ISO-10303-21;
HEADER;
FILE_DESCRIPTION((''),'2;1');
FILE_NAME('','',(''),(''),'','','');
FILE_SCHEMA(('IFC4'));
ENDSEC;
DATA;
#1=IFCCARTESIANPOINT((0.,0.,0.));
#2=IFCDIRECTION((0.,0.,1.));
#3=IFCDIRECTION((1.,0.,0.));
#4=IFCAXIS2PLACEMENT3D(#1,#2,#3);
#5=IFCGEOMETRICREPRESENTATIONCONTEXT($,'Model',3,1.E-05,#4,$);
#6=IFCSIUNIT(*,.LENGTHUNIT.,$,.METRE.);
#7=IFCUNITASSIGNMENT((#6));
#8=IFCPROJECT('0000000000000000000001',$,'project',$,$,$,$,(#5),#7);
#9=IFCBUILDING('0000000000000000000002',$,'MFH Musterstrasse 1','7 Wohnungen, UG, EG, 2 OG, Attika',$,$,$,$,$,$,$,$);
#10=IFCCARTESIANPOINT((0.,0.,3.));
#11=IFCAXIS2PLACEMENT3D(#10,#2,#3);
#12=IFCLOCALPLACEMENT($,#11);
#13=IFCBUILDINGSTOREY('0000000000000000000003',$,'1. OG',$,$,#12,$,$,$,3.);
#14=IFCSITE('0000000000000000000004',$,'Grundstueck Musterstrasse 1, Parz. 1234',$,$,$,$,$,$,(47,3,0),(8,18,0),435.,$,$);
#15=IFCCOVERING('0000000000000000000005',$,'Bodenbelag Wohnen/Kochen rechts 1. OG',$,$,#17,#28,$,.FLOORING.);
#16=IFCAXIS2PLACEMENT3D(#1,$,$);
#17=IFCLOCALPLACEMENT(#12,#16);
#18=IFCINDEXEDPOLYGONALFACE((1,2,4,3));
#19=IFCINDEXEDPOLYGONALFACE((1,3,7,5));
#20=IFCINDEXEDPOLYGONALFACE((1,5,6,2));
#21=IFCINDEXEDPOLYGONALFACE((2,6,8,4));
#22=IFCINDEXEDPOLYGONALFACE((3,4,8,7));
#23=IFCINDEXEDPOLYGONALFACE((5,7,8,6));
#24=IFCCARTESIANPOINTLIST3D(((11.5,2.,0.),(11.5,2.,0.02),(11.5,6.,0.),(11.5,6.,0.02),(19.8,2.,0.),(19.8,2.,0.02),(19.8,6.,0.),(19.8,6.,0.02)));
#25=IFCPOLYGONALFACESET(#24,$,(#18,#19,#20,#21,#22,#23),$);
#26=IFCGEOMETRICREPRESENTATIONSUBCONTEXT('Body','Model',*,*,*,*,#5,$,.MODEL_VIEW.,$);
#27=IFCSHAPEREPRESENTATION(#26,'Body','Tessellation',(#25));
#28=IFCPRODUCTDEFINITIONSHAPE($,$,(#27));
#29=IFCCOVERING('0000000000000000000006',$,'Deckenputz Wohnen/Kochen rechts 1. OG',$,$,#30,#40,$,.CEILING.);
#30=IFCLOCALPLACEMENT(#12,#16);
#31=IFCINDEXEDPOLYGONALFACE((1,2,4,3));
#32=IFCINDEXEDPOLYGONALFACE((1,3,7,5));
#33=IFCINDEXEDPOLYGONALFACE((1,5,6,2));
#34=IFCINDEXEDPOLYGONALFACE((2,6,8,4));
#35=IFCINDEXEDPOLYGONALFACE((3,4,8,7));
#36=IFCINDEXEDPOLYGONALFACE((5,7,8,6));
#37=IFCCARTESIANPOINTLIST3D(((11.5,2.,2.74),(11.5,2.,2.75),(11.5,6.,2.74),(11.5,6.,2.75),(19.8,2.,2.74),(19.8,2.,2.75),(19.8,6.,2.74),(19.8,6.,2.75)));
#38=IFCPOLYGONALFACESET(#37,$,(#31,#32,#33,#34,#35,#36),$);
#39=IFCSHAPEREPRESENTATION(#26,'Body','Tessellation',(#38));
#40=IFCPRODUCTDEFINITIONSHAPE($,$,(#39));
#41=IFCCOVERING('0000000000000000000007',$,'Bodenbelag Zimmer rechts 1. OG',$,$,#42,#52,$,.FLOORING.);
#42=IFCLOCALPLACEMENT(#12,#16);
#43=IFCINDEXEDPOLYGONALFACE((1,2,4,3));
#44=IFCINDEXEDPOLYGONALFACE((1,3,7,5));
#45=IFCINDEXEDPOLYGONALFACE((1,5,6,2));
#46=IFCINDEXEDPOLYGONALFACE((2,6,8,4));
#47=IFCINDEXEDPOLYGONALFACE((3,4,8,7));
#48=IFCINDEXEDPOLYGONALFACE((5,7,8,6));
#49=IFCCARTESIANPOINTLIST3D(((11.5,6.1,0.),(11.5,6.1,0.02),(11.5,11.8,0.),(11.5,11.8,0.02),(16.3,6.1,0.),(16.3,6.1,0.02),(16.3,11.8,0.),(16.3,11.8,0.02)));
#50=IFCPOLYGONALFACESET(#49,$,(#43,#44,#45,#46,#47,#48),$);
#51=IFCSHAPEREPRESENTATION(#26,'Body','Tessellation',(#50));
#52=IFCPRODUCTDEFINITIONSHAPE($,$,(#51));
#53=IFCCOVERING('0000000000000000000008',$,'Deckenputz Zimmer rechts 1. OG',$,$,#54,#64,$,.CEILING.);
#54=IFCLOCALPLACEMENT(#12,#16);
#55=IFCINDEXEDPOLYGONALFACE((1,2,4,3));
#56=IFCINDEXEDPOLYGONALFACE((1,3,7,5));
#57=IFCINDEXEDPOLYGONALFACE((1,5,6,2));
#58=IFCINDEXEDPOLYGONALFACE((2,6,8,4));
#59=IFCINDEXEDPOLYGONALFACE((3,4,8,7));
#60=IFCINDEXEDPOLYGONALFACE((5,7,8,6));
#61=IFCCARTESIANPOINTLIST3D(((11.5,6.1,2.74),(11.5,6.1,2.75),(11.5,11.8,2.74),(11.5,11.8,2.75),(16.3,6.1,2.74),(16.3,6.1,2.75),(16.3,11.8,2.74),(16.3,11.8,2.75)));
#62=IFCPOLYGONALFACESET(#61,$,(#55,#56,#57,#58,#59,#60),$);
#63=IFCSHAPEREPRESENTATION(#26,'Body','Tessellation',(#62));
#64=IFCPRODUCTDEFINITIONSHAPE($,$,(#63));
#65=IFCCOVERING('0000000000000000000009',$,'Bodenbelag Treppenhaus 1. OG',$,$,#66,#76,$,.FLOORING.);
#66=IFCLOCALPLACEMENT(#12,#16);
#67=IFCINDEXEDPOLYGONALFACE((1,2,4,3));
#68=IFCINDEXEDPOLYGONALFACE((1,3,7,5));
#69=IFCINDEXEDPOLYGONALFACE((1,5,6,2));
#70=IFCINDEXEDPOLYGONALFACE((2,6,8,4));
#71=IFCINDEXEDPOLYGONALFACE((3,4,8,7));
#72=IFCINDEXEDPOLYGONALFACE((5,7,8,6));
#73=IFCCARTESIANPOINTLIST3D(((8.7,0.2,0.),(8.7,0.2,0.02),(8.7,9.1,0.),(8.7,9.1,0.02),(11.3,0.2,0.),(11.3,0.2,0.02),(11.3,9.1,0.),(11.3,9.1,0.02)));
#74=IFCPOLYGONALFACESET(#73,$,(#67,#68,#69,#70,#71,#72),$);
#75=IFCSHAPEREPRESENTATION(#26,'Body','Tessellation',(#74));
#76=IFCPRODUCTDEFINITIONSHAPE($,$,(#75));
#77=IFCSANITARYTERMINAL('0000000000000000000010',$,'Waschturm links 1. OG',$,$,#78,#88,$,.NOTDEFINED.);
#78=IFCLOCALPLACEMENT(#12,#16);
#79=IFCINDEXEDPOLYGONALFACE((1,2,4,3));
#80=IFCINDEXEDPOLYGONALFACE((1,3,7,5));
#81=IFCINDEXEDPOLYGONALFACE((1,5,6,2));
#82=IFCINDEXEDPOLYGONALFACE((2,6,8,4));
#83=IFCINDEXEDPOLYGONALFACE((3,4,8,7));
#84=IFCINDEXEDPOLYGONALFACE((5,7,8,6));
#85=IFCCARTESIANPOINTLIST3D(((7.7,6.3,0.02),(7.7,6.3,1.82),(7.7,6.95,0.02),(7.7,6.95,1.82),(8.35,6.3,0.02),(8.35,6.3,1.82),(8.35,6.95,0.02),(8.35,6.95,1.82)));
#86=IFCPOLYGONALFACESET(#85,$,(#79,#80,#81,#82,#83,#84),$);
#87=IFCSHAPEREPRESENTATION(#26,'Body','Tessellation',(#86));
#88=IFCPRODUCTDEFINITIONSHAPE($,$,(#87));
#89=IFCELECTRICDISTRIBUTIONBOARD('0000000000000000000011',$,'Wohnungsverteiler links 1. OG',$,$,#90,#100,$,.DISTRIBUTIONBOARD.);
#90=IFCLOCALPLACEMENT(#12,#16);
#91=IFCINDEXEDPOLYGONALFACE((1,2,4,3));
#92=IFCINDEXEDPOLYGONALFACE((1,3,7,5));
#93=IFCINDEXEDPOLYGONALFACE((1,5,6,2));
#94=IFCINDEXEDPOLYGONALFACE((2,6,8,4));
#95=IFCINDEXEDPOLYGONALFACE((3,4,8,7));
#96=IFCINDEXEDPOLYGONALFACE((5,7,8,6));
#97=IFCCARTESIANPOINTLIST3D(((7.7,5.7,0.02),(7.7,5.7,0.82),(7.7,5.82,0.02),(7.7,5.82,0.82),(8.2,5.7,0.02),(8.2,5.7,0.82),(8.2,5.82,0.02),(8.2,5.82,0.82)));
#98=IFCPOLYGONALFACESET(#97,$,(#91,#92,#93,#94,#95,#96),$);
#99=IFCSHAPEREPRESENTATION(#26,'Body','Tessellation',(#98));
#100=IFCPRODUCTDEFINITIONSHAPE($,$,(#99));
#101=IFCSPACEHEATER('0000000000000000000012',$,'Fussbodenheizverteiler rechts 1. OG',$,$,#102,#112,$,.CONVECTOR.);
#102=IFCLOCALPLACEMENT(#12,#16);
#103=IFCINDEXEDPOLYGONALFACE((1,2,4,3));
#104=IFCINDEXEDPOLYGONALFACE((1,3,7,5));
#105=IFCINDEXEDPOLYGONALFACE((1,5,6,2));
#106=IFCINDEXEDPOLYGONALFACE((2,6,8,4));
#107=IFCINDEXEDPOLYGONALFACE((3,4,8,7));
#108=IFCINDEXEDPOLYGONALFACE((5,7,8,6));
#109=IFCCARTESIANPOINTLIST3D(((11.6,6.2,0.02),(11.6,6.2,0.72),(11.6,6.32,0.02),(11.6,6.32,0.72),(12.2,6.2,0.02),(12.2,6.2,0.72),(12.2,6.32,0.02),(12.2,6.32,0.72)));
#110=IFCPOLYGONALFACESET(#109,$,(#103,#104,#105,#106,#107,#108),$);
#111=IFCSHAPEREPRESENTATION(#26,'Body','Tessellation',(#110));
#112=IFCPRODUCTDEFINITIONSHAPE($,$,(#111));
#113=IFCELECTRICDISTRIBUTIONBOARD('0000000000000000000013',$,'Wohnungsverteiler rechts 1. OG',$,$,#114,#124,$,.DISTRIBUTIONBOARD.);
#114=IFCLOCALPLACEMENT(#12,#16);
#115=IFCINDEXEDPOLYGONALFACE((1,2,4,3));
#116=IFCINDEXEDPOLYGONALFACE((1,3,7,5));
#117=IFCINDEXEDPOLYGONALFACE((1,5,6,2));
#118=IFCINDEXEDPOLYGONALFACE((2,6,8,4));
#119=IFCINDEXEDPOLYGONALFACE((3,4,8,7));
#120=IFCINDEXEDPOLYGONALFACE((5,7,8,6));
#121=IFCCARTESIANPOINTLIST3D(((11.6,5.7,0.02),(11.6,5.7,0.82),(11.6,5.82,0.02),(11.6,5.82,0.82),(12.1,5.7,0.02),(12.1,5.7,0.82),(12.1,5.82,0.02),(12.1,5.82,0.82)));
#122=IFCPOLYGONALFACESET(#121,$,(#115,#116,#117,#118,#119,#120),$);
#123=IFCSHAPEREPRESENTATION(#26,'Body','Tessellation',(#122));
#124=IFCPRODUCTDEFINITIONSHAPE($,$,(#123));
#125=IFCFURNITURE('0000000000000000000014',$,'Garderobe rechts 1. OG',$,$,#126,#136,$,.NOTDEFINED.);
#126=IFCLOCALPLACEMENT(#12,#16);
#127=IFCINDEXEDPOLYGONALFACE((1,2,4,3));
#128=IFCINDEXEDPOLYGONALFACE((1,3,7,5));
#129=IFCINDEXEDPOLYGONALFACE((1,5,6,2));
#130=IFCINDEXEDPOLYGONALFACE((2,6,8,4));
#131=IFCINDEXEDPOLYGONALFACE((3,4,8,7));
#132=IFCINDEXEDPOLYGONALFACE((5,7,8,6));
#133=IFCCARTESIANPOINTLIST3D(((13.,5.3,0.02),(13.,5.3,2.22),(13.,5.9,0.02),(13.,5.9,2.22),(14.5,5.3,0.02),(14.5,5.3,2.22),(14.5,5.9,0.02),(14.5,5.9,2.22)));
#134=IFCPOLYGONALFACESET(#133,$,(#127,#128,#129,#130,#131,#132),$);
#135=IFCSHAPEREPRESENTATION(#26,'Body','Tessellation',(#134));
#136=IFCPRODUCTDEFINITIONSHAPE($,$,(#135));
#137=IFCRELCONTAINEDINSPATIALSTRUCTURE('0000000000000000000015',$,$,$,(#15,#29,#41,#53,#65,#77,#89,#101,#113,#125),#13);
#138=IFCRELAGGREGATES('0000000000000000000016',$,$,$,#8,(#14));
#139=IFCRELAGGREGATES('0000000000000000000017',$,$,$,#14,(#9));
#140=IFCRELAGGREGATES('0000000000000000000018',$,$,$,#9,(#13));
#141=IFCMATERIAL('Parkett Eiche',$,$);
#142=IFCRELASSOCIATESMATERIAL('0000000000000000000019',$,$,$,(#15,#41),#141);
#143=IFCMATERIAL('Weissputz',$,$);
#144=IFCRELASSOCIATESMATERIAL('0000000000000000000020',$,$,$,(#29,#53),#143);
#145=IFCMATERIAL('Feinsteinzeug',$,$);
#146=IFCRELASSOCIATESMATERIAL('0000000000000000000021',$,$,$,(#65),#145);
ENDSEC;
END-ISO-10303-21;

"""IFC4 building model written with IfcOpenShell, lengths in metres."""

from ifc_helpers import new_model, si_unit, frame, frame_2d, origin_with_axes, place, context, subcontext, project, spatial, rectangle, extrude, material, element, save


model = new_model("IFC4")

# Units and contexts
model_context = context("Model", 3, precision=1e-05, world=origin_with_axes())
body_context = subcontext(model_context, "Body", "Model", "MODEL_VIEW")
ifc_project = project(units=[si_unit("LENGTHUNIT", "METRE")], contexts=[model_context])

# Site, building, storey
site = spatial("IfcSite", under=ifc_project, Name="Grundstueck Musterstrasse 1, Parz. 1234", RefLatitude=(47, 3, 0), RefLongitude=(8, 18, 0), RefElevation=435.0)
building = spatial("IfcBuilding", under=site, Name="MFH Musterstrasse 1", Description="7 Wohnungen, UG, EG, 2 OG, Attika")
storey_placement = place(None, frame((0.0, 0.0, 3.0), z_axis=(0.0, 0.0, 1.0), x_axis=(1.0, 0.0, 0.0)))
storey = spatial("IfcBuildingStorey", under=building, at=storey_placement, Name="1. OG", Elevation=3.0)

# Coverings
ifc_material_1 = material(Name="Parkett Eiche")
covering_1_placement = place(storey_placement, frame((11.5, 2.0, 0.0), z_axis=(0.0, 0.0, 1.0), x_axis=(1.0, 0.0, 0.0)))
element("IfcCovering", 1, at=covering_1_placement, inside=storey, material=ifc_material_1, Name="Bodenbelag Wohnen/Kochen rechts 1. OG", PredefinedType="FLOORING", context=body_context, shape_type="SweptSolid", body=[
    extrude(rectangle(XDim=8.3, YDim=4.0, at=frame_2d((4.15, 2.0))), origin_with_axes(), (0.0, 0.0, 1.0), 0.02),
])
ifc_material_2 = material(Name="Weissputz")
covering_2_placement = place(storey_placement, frame((11.5, 2.0, 2.74), z_axis=(0.0, 0.0, 1.0), x_axis=(1.0, 0.0, 0.0)))
element("IfcCovering", 2, at=covering_2_placement, inside=storey, material=ifc_material_2, Name="Deckenputz Wohnen/Kochen rechts 1. OG", PredefinedType="CEILING", context=body_context, shape_type="SweptSolid", body=[
    extrude(rectangle(XDim=8.3, YDim=4.0, at=frame_2d((4.15, 2.0))), origin_with_axes(), (0.0, 0.0, 1.0), 0.01),
])
covering_3_placement = place(storey_placement, frame((11.5, 6.1, 0.0), z_axis=(0.0, 0.0, 1.0), x_axis=(1.0, 0.0, 0.0)))
element("IfcCovering", 3, at=covering_3_placement, inside=storey, material=ifc_material_1, Name="Bodenbelag Zimmer rechts 1. OG", PredefinedType="FLOORING", context=body_context, shape_type="SweptSolid", body=[
    extrude(rectangle(XDim=4.8, YDim=5.7, at=frame_2d((2.4, 2.85))), origin_with_axes(), (0.0, 0.0, 1.0), 0.02),
])
covering_4_placement = place(storey_placement, frame((11.5, 6.1, 2.74), z_axis=(0.0, 0.0, 1.0), x_axis=(1.0, 0.0, 0.0)))
element("IfcCovering", 4, at=covering_4_placement, inside=storey, material=ifc_material_2, Name="Deckenputz Zimmer rechts 1. OG", PredefinedType="CEILING", context=body_context, shape_type="SweptSolid", body=[
    extrude(rectangle(XDim=4.8, YDim=5.7, at=frame_2d((2.4, 2.85))), origin_with_axes(), (0.0, 0.0, 1.0), 0.01),
])
ifc_material_3 = material(Name="Feinsteinzeug")
covering_5_placement = place(storey_placement, frame((8.7, 0.2, 0.0), z_axis=(0.0, 0.0, 1.0), x_axis=(1.0, 0.0, 0.0)))
element("IfcCovering", 5, at=covering_5_placement, inside=storey, material=ifc_material_3, Name="Bodenbelag Treppenhaus 1. OG", PredefinedType="FLOORING", context=body_context, shape_type="SweptSolid", body=[
    extrude(rectangle(XDim=2.6, YDim=8.9, at=frame_2d((1.3, 4.45))), origin_with_axes(), (0.0, 0.0, 1.0), 0.02),
])

# Sanitary terminal
sanitary_terminal_placement = place(storey_placement, frame((7.7, 6.3, 0.02), z_axis=(0.0, 0.0, 1.0), x_axis=(1.0, 0.0, 0.0)))
element("IfcSanitaryTerminal", 6, at=sanitary_terminal_placement, inside=storey, Name="Waschturm links 1. OG", PredefinedType="NOTDEFINED", context=body_context, shape_type="SweptSolid", body=[
    extrude(rectangle(XDim=0.65, YDim=0.65, at=frame_2d((0.325, 0.325))), origin_with_axes(), (0.0, 0.0, 1.0), 1.8),
])

# Electric distribution board
electric_distribution_board_1_placement = place(storey_placement, frame((7.7, 5.7, 0.02), z_axis=(0.0, 0.0, 1.0), x_axis=(1.0, 0.0, 0.0)))
element("IfcElectricDistributionBoard", 7, at=electric_distribution_board_1_placement, inside=storey, Name="Wohnungsverteiler links 1. OG", PredefinedType="DISTRIBUTIONBOARD", context=body_context, shape_type="SweptSolid", body=[
    extrude(rectangle(XDim=0.5, YDim=0.12, at=frame_2d((0.25, 0.06))), origin_with_axes(), (0.0, 0.0, 1.0), 0.8),
])

# Space heater
space_heater_placement = place(storey_placement, frame((11.6, 6.2, 0.02), z_axis=(0.0, 0.0, 1.0), x_axis=(1.0, 0.0, 0.0)))
element("IfcSpaceHeater", 8, at=space_heater_placement, inside=storey, Name="Fussbodenheizverteiler rechts 1. OG", PredefinedType="CONVECTOR", context=body_context, shape_type="SweptSolid", body=[
    extrude(rectangle(XDim=0.6, YDim=0.12, at=frame_2d((0.3, 0.06))), origin_with_axes(), (0.0, 0.0, 1.0), 0.7),
])

# Electric distribution board
electric_distribution_board_2_placement = place(storey_placement, frame((11.6, 5.7, 0.02), z_axis=(0.0, 0.0, 1.0), x_axis=(1.0, 0.0, 0.0)))
element("IfcElectricDistributionBoard", 9, at=electric_distribution_board_2_placement, inside=storey, Name="Wohnungsverteiler rechts 1. OG", PredefinedType="DISTRIBUTIONBOARD", context=body_context, shape_type="SweptSolid", body=[
    extrude(rectangle(XDim=0.5, YDim=0.12, at=frame_2d((0.25, 0.06))), origin_with_axes(), (0.0, 0.0, 1.0), 0.8),
])

# Furniture
furniture_placement = place(storey_placement, frame((13.0, 5.3, 0.02), z_axis=(0.0, 0.0, 1.0), x_axis=(1.0, 0.0, 0.0)))
element("IfcFurniture", 10, at=furniture_placement, inside=storey, Name="Garderobe rechts 1. OG", PredefinedType="NOTDEFINED", context=body_context, shape_type="SweptSolid", body=[
    extrude(rectangle(XDim=1.5, YDim=0.6, at=frame_2d((0.75, 0.3))), origin_with_axes(), (0.0, 0.0, 1.0), 2.2),
])

save(model, "model.ifc")
